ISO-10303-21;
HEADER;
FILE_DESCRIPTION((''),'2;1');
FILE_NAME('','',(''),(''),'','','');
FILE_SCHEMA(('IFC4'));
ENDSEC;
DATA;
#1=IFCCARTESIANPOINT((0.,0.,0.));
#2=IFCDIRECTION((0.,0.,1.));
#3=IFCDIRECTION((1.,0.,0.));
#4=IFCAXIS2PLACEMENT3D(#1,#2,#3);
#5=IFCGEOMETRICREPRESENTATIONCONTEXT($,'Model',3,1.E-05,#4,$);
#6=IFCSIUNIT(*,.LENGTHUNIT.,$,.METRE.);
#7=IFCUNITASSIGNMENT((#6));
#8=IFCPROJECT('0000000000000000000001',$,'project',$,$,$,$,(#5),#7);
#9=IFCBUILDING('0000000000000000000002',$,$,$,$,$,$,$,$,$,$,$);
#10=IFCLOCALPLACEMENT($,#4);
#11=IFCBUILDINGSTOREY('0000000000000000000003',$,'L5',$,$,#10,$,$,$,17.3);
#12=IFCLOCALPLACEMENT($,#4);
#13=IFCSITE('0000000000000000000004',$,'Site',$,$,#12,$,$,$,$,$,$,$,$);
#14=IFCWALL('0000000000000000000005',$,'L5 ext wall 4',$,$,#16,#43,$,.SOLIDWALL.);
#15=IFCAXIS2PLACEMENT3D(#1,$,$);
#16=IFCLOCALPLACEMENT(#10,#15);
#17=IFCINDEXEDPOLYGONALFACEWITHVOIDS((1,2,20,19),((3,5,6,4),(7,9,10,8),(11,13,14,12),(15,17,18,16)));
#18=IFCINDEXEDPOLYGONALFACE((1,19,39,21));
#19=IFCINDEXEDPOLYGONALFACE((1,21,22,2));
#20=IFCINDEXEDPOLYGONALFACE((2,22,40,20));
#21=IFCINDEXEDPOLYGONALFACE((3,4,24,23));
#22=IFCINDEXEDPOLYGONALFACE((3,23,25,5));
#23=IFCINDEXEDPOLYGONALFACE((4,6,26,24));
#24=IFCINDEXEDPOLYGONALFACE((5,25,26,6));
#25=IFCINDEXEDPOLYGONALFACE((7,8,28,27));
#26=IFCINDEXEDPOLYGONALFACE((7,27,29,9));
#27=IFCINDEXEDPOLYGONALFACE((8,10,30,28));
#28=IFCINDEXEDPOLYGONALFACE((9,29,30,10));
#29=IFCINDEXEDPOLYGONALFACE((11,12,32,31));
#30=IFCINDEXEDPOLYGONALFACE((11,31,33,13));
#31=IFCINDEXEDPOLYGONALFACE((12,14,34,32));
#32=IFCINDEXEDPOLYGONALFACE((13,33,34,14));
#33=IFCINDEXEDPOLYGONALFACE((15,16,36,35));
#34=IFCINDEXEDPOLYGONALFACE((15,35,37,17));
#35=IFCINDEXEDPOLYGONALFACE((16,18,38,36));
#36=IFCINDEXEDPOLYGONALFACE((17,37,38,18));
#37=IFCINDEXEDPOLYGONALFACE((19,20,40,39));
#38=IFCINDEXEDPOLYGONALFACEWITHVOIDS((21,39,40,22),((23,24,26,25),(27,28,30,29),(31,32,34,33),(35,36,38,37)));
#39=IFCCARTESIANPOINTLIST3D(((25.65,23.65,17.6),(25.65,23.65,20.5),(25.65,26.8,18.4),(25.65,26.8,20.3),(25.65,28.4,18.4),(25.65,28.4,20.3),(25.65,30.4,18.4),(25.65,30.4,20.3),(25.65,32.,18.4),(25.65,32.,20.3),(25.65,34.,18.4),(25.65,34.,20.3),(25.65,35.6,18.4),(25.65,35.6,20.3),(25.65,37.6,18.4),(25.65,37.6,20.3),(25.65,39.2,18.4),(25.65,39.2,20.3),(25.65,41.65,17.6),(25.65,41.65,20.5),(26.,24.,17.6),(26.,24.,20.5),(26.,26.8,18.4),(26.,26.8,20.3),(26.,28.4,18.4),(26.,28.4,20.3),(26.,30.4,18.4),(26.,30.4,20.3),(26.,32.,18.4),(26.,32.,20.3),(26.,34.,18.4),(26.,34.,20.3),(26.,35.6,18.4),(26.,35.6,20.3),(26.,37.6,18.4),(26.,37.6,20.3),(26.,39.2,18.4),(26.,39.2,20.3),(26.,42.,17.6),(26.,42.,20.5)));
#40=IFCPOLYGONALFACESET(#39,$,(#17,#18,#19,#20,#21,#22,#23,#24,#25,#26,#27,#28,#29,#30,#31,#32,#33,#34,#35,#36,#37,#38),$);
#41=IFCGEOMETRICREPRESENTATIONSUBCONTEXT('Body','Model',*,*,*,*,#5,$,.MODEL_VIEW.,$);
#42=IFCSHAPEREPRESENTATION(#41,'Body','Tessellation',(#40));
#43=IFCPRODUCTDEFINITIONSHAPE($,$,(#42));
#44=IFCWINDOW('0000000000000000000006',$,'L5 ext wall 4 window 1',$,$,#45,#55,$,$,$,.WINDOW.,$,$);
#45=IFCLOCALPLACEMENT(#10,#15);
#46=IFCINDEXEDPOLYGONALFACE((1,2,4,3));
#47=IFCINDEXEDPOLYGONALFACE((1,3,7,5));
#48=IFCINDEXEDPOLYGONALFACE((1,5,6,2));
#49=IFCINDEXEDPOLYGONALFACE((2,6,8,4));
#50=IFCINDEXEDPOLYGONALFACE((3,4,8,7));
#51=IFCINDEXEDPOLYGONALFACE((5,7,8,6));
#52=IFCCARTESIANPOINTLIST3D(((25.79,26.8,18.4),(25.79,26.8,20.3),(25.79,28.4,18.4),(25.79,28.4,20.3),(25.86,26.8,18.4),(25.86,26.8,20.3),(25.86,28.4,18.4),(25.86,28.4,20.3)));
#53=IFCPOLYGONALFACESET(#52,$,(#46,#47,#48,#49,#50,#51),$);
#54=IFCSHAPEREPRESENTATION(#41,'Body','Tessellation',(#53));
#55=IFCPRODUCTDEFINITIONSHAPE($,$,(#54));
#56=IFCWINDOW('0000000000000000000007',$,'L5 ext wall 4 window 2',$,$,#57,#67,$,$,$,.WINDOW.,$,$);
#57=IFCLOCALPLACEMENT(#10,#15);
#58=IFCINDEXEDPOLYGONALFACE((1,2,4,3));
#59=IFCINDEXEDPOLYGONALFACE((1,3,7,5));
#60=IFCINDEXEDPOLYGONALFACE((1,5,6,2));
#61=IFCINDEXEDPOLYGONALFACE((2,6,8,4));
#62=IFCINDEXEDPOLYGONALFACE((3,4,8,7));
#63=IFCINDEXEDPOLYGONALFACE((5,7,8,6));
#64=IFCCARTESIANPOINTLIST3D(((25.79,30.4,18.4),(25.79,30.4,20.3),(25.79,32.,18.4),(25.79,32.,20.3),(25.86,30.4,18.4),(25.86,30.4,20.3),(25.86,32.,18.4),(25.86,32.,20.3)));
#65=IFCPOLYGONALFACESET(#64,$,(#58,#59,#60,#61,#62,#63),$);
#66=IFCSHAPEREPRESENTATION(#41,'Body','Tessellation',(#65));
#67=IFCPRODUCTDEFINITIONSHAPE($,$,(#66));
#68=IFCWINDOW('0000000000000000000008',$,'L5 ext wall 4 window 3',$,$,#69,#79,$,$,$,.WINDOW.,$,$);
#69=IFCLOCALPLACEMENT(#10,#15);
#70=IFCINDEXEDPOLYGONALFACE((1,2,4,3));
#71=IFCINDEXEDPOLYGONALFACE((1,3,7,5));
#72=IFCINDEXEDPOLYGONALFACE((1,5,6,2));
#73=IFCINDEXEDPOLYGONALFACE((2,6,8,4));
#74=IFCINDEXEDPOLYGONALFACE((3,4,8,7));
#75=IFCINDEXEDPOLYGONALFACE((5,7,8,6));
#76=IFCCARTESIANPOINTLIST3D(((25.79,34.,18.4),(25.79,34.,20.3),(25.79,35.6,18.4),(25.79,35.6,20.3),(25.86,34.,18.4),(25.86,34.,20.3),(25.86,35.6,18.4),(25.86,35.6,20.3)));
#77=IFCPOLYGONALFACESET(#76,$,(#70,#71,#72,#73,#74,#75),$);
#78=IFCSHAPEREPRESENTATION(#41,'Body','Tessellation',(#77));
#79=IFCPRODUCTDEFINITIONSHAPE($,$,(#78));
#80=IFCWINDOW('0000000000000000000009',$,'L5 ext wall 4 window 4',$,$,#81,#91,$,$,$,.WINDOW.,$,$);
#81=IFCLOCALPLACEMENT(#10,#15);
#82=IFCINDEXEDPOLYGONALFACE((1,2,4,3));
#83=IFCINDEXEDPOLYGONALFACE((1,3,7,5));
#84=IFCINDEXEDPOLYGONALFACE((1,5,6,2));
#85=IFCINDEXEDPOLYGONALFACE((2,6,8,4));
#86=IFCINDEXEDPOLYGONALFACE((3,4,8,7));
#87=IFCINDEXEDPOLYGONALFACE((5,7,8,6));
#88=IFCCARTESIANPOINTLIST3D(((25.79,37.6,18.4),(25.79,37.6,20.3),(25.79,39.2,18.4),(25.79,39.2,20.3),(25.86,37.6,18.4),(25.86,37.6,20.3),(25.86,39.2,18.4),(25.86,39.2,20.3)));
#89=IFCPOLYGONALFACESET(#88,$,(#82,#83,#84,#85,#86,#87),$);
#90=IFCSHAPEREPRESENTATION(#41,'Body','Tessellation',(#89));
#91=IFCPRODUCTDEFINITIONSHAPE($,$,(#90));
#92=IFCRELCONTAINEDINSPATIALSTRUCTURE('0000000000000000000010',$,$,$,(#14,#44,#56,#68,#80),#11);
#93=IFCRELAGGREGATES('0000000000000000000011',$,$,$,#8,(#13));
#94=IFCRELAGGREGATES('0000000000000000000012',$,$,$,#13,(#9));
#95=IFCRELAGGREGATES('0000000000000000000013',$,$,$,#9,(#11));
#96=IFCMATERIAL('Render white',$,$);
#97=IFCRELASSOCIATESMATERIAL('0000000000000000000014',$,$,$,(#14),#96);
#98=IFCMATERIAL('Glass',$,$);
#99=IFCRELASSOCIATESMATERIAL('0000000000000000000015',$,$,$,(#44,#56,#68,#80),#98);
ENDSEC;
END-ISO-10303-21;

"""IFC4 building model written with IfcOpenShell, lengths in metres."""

from ifc_helpers import new_model, si_unit, frame, origin_with_axes, place, context, subcontext, project, spatial, polyline, outline, extrude, material, element, fill, save


model = new_model("IFC4")

# Units and contexts
model_context = context("Model", 3, precision=1e-05, world=origin_with_axes())
body_context = subcontext(model_context, "Body", "Model", "MODEL_VIEW")
ifc_project = project(units=[si_unit("LENGTHUNIT", "METRE")], contexts=[model_context])

# Site, building, storey
site_placement = place(None, origin_with_axes())
site = spatial("IfcSite", under=ifc_project, at=site_placement, Name="Site")
building = spatial("IfcBuilding", under=site)
storey_placement = place(None, origin_with_axes())
storey = spatial("IfcBuildingStorey", under=building, at=storey_placement, Name="L5", Elevation=17.3)

# Wall, openings, windows
ifc_material_1 = material(Name="Render white")
ifc_material_2 = material(Name="Glass")
wall_1_placement = place(storey_placement, origin_with_axes())
wall_1 = element("IfcWall", 1, at=wall_1_placement, inside=storey, material=ifc_material_1, Name="L5 ext wall 4", PredefinedType="SOLIDWALL", context=body_context, shape_type="SweptSolid", body=[
    extrude(outline(polyline([(26.0, 24.0), (26.0, 42.0), (25.65, 41.65), (25.65, 23.65), (26.0, 24.0)])), frame((0.0, 0.0, 17.6), z_axis=(0.0, 0.0, 1.0), x_axis=(1.0, 0.0, 0.0)), (0.0, 0.0, 1.0), 2.9),
])
opening_1_placement = place(wall_1_placement, origin_with_axes())
opening_1 = element("IfcOpeningElement", 2, at=opening_1_placement, cuts=wall_1, context=body_context, shape_type="SweptSolid", body=[
    extrude(outline(polyline([(26.05, 26.8), (26.05, 28.4), (25.6, 28.4), (25.6, 26.8), (26.05, 26.8)])), frame((0.0, 0.0, 18.4), z_axis=(0.0, 0.0, 1.0), x_axis=(1.0, 0.0, 0.0)), (0.0, 0.0, 1.0), 1.9),
])
opening_2_placement = place(wall_1_placement, origin_with_axes())
opening_2 = element("IfcOpeningElement", 3, at=opening_2_placement, cuts=wall_1, context=body_context, shape_type="SweptSolid", body=[
    extrude(outline(polyline([(26.05, 30.4), (26.05, 32.0), (25.6, 32.0), (25.6, 30.4), (26.05, 30.4)])), frame((0.0, 0.0, 18.4), z_axis=(0.0, 0.0, 1.0), x_axis=(1.0, 0.0, 0.0)), (0.0, 0.0, 1.0), 1.9),
])
opening_3_placement = place(wall_1_placement, origin_with_axes())
opening_3 = element("IfcOpeningElement", 4, at=opening_3_placement, cuts=wall_1, context=body_context, shape_type="SweptSolid", body=[
    extrude(outline(polyline([(26.05, 34.0), (26.05, 35.6), (25.6, 35.6), (25.6, 34.0), (26.05, 34.0)])), frame((0.0, 0.0, 18.4), z_axis=(0.0, 0.0, 1.0), x_axis=(1.0, 0.0, 0.0)), (0.0, 0.0, 1.0), 1.9),
])
opening_4_placement = place(wall_1_placement, origin_with_axes())
opening_4 = element("IfcOpeningElement", 5, at=opening_4_placement, cuts=wall_1, context=body_context, shape_type="SweptSolid", body=[
    extrude(outline(polyline([(26.05, 37.6), (26.05, 39.2), (25.6, 39.2), (25.6, 37.6), (26.05, 37.6)])), frame((0.0, 0.0, 18.4), z_axis=(0.0, 0.0, 1.0), x_axis=(1.0, 0.0, 0.0)), (0.0, 0.0, 1.0), 1.9),
])
window_1_placement = place(storey_placement, origin_with_axes())
window_1 = element("IfcWindow", 6, at=window_1_placement, inside=storey, material=ifc_material_2, Name="L5 ext wall 4 window 1", PredefinedType="WINDOW", context=body_context, shape_type="SweptSolid", body=[
    extrude(outline(polyline([(25.86, 26.8), (25.86, 28.4), (25.79, 28.4), (25.79, 26.8), (25.86, 26.8)])), frame((0.0, 0.0, 18.4), z_axis=(0.0, 0.0, 1.0), x_axis=(1.0, 0.0, 0.0)), (0.0, 0.0, 1.0), 1.9),
])
fill(opening_1, window_1)
window_2_placement = place(storey_placement, origin_with_axes())
window_2 = element("IfcWindow", 7, at=window_2_placement, inside=storey, material=ifc_material_2, Name="L5 ext wall 4 window 2", PredefinedType="WINDOW", context=body_context, shape_type="SweptSolid", body=[
    extrude(outline(polyline([(25.86, 30.4), (25.86, 32.0), (25.79, 32.0), (25.79, 30.4), (25.86, 30.4)])), frame((0.0, 0.0, 18.4), z_axis=(0.0, 0.0, 1.0), x_axis=(1.0, 0.0, 0.0)), (0.0, 0.0, 1.0), 1.9),
])
fill(opening_2, window_2)
window_3_placement = place(storey_placement, origin_with_axes())
window_3 = element("IfcWindow", 8, at=window_3_placement, inside=storey, material=ifc_material_2, Name="L5 ext wall 4 window 3", PredefinedType="WINDOW", context=body_context, shape_type="SweptSolid", body=[
    extrude(outline(polyline([(25.86, 34.0), (25.86, 35.6), (25.79, 35.6), (25.79, 34.0), (25.86, 34.0)])), frame((0.0, 0.0, 18.4), z_axis=(0.0, 0.0, 1.0), x_axis=(1.0, 0.0, 0.0)), (0.0, 0.0, 1.0), 1.9),
])
fill(opening_3, window_3)
window_4_placement = place(storey_placement, origin_with_axes())
window_4 = element("IfcWindow", 9, at=window_4_placement, inside=storey, material=ifc_material_2, Name="L5 ext wall 4 window 4", PredefinedType="WINDOW", context=body_context, shape_type="SweptSolid", body=[
    extrude(outline(polyline([(25.86, 37.6), (25.86, 39.2), (25.79, 39.2), (25.79, 37.6), (25.86, 37.6)])), frame((0.0, 0.0, 18.4), z_axis=(0.0, 0.0, 1.0), x_axis=(1.0, 0.0, 0.0)), (0.0, 0.0, 1.0), 1.9),
])
fill(opening_4, window_4)

save(model, "model.ifc")
